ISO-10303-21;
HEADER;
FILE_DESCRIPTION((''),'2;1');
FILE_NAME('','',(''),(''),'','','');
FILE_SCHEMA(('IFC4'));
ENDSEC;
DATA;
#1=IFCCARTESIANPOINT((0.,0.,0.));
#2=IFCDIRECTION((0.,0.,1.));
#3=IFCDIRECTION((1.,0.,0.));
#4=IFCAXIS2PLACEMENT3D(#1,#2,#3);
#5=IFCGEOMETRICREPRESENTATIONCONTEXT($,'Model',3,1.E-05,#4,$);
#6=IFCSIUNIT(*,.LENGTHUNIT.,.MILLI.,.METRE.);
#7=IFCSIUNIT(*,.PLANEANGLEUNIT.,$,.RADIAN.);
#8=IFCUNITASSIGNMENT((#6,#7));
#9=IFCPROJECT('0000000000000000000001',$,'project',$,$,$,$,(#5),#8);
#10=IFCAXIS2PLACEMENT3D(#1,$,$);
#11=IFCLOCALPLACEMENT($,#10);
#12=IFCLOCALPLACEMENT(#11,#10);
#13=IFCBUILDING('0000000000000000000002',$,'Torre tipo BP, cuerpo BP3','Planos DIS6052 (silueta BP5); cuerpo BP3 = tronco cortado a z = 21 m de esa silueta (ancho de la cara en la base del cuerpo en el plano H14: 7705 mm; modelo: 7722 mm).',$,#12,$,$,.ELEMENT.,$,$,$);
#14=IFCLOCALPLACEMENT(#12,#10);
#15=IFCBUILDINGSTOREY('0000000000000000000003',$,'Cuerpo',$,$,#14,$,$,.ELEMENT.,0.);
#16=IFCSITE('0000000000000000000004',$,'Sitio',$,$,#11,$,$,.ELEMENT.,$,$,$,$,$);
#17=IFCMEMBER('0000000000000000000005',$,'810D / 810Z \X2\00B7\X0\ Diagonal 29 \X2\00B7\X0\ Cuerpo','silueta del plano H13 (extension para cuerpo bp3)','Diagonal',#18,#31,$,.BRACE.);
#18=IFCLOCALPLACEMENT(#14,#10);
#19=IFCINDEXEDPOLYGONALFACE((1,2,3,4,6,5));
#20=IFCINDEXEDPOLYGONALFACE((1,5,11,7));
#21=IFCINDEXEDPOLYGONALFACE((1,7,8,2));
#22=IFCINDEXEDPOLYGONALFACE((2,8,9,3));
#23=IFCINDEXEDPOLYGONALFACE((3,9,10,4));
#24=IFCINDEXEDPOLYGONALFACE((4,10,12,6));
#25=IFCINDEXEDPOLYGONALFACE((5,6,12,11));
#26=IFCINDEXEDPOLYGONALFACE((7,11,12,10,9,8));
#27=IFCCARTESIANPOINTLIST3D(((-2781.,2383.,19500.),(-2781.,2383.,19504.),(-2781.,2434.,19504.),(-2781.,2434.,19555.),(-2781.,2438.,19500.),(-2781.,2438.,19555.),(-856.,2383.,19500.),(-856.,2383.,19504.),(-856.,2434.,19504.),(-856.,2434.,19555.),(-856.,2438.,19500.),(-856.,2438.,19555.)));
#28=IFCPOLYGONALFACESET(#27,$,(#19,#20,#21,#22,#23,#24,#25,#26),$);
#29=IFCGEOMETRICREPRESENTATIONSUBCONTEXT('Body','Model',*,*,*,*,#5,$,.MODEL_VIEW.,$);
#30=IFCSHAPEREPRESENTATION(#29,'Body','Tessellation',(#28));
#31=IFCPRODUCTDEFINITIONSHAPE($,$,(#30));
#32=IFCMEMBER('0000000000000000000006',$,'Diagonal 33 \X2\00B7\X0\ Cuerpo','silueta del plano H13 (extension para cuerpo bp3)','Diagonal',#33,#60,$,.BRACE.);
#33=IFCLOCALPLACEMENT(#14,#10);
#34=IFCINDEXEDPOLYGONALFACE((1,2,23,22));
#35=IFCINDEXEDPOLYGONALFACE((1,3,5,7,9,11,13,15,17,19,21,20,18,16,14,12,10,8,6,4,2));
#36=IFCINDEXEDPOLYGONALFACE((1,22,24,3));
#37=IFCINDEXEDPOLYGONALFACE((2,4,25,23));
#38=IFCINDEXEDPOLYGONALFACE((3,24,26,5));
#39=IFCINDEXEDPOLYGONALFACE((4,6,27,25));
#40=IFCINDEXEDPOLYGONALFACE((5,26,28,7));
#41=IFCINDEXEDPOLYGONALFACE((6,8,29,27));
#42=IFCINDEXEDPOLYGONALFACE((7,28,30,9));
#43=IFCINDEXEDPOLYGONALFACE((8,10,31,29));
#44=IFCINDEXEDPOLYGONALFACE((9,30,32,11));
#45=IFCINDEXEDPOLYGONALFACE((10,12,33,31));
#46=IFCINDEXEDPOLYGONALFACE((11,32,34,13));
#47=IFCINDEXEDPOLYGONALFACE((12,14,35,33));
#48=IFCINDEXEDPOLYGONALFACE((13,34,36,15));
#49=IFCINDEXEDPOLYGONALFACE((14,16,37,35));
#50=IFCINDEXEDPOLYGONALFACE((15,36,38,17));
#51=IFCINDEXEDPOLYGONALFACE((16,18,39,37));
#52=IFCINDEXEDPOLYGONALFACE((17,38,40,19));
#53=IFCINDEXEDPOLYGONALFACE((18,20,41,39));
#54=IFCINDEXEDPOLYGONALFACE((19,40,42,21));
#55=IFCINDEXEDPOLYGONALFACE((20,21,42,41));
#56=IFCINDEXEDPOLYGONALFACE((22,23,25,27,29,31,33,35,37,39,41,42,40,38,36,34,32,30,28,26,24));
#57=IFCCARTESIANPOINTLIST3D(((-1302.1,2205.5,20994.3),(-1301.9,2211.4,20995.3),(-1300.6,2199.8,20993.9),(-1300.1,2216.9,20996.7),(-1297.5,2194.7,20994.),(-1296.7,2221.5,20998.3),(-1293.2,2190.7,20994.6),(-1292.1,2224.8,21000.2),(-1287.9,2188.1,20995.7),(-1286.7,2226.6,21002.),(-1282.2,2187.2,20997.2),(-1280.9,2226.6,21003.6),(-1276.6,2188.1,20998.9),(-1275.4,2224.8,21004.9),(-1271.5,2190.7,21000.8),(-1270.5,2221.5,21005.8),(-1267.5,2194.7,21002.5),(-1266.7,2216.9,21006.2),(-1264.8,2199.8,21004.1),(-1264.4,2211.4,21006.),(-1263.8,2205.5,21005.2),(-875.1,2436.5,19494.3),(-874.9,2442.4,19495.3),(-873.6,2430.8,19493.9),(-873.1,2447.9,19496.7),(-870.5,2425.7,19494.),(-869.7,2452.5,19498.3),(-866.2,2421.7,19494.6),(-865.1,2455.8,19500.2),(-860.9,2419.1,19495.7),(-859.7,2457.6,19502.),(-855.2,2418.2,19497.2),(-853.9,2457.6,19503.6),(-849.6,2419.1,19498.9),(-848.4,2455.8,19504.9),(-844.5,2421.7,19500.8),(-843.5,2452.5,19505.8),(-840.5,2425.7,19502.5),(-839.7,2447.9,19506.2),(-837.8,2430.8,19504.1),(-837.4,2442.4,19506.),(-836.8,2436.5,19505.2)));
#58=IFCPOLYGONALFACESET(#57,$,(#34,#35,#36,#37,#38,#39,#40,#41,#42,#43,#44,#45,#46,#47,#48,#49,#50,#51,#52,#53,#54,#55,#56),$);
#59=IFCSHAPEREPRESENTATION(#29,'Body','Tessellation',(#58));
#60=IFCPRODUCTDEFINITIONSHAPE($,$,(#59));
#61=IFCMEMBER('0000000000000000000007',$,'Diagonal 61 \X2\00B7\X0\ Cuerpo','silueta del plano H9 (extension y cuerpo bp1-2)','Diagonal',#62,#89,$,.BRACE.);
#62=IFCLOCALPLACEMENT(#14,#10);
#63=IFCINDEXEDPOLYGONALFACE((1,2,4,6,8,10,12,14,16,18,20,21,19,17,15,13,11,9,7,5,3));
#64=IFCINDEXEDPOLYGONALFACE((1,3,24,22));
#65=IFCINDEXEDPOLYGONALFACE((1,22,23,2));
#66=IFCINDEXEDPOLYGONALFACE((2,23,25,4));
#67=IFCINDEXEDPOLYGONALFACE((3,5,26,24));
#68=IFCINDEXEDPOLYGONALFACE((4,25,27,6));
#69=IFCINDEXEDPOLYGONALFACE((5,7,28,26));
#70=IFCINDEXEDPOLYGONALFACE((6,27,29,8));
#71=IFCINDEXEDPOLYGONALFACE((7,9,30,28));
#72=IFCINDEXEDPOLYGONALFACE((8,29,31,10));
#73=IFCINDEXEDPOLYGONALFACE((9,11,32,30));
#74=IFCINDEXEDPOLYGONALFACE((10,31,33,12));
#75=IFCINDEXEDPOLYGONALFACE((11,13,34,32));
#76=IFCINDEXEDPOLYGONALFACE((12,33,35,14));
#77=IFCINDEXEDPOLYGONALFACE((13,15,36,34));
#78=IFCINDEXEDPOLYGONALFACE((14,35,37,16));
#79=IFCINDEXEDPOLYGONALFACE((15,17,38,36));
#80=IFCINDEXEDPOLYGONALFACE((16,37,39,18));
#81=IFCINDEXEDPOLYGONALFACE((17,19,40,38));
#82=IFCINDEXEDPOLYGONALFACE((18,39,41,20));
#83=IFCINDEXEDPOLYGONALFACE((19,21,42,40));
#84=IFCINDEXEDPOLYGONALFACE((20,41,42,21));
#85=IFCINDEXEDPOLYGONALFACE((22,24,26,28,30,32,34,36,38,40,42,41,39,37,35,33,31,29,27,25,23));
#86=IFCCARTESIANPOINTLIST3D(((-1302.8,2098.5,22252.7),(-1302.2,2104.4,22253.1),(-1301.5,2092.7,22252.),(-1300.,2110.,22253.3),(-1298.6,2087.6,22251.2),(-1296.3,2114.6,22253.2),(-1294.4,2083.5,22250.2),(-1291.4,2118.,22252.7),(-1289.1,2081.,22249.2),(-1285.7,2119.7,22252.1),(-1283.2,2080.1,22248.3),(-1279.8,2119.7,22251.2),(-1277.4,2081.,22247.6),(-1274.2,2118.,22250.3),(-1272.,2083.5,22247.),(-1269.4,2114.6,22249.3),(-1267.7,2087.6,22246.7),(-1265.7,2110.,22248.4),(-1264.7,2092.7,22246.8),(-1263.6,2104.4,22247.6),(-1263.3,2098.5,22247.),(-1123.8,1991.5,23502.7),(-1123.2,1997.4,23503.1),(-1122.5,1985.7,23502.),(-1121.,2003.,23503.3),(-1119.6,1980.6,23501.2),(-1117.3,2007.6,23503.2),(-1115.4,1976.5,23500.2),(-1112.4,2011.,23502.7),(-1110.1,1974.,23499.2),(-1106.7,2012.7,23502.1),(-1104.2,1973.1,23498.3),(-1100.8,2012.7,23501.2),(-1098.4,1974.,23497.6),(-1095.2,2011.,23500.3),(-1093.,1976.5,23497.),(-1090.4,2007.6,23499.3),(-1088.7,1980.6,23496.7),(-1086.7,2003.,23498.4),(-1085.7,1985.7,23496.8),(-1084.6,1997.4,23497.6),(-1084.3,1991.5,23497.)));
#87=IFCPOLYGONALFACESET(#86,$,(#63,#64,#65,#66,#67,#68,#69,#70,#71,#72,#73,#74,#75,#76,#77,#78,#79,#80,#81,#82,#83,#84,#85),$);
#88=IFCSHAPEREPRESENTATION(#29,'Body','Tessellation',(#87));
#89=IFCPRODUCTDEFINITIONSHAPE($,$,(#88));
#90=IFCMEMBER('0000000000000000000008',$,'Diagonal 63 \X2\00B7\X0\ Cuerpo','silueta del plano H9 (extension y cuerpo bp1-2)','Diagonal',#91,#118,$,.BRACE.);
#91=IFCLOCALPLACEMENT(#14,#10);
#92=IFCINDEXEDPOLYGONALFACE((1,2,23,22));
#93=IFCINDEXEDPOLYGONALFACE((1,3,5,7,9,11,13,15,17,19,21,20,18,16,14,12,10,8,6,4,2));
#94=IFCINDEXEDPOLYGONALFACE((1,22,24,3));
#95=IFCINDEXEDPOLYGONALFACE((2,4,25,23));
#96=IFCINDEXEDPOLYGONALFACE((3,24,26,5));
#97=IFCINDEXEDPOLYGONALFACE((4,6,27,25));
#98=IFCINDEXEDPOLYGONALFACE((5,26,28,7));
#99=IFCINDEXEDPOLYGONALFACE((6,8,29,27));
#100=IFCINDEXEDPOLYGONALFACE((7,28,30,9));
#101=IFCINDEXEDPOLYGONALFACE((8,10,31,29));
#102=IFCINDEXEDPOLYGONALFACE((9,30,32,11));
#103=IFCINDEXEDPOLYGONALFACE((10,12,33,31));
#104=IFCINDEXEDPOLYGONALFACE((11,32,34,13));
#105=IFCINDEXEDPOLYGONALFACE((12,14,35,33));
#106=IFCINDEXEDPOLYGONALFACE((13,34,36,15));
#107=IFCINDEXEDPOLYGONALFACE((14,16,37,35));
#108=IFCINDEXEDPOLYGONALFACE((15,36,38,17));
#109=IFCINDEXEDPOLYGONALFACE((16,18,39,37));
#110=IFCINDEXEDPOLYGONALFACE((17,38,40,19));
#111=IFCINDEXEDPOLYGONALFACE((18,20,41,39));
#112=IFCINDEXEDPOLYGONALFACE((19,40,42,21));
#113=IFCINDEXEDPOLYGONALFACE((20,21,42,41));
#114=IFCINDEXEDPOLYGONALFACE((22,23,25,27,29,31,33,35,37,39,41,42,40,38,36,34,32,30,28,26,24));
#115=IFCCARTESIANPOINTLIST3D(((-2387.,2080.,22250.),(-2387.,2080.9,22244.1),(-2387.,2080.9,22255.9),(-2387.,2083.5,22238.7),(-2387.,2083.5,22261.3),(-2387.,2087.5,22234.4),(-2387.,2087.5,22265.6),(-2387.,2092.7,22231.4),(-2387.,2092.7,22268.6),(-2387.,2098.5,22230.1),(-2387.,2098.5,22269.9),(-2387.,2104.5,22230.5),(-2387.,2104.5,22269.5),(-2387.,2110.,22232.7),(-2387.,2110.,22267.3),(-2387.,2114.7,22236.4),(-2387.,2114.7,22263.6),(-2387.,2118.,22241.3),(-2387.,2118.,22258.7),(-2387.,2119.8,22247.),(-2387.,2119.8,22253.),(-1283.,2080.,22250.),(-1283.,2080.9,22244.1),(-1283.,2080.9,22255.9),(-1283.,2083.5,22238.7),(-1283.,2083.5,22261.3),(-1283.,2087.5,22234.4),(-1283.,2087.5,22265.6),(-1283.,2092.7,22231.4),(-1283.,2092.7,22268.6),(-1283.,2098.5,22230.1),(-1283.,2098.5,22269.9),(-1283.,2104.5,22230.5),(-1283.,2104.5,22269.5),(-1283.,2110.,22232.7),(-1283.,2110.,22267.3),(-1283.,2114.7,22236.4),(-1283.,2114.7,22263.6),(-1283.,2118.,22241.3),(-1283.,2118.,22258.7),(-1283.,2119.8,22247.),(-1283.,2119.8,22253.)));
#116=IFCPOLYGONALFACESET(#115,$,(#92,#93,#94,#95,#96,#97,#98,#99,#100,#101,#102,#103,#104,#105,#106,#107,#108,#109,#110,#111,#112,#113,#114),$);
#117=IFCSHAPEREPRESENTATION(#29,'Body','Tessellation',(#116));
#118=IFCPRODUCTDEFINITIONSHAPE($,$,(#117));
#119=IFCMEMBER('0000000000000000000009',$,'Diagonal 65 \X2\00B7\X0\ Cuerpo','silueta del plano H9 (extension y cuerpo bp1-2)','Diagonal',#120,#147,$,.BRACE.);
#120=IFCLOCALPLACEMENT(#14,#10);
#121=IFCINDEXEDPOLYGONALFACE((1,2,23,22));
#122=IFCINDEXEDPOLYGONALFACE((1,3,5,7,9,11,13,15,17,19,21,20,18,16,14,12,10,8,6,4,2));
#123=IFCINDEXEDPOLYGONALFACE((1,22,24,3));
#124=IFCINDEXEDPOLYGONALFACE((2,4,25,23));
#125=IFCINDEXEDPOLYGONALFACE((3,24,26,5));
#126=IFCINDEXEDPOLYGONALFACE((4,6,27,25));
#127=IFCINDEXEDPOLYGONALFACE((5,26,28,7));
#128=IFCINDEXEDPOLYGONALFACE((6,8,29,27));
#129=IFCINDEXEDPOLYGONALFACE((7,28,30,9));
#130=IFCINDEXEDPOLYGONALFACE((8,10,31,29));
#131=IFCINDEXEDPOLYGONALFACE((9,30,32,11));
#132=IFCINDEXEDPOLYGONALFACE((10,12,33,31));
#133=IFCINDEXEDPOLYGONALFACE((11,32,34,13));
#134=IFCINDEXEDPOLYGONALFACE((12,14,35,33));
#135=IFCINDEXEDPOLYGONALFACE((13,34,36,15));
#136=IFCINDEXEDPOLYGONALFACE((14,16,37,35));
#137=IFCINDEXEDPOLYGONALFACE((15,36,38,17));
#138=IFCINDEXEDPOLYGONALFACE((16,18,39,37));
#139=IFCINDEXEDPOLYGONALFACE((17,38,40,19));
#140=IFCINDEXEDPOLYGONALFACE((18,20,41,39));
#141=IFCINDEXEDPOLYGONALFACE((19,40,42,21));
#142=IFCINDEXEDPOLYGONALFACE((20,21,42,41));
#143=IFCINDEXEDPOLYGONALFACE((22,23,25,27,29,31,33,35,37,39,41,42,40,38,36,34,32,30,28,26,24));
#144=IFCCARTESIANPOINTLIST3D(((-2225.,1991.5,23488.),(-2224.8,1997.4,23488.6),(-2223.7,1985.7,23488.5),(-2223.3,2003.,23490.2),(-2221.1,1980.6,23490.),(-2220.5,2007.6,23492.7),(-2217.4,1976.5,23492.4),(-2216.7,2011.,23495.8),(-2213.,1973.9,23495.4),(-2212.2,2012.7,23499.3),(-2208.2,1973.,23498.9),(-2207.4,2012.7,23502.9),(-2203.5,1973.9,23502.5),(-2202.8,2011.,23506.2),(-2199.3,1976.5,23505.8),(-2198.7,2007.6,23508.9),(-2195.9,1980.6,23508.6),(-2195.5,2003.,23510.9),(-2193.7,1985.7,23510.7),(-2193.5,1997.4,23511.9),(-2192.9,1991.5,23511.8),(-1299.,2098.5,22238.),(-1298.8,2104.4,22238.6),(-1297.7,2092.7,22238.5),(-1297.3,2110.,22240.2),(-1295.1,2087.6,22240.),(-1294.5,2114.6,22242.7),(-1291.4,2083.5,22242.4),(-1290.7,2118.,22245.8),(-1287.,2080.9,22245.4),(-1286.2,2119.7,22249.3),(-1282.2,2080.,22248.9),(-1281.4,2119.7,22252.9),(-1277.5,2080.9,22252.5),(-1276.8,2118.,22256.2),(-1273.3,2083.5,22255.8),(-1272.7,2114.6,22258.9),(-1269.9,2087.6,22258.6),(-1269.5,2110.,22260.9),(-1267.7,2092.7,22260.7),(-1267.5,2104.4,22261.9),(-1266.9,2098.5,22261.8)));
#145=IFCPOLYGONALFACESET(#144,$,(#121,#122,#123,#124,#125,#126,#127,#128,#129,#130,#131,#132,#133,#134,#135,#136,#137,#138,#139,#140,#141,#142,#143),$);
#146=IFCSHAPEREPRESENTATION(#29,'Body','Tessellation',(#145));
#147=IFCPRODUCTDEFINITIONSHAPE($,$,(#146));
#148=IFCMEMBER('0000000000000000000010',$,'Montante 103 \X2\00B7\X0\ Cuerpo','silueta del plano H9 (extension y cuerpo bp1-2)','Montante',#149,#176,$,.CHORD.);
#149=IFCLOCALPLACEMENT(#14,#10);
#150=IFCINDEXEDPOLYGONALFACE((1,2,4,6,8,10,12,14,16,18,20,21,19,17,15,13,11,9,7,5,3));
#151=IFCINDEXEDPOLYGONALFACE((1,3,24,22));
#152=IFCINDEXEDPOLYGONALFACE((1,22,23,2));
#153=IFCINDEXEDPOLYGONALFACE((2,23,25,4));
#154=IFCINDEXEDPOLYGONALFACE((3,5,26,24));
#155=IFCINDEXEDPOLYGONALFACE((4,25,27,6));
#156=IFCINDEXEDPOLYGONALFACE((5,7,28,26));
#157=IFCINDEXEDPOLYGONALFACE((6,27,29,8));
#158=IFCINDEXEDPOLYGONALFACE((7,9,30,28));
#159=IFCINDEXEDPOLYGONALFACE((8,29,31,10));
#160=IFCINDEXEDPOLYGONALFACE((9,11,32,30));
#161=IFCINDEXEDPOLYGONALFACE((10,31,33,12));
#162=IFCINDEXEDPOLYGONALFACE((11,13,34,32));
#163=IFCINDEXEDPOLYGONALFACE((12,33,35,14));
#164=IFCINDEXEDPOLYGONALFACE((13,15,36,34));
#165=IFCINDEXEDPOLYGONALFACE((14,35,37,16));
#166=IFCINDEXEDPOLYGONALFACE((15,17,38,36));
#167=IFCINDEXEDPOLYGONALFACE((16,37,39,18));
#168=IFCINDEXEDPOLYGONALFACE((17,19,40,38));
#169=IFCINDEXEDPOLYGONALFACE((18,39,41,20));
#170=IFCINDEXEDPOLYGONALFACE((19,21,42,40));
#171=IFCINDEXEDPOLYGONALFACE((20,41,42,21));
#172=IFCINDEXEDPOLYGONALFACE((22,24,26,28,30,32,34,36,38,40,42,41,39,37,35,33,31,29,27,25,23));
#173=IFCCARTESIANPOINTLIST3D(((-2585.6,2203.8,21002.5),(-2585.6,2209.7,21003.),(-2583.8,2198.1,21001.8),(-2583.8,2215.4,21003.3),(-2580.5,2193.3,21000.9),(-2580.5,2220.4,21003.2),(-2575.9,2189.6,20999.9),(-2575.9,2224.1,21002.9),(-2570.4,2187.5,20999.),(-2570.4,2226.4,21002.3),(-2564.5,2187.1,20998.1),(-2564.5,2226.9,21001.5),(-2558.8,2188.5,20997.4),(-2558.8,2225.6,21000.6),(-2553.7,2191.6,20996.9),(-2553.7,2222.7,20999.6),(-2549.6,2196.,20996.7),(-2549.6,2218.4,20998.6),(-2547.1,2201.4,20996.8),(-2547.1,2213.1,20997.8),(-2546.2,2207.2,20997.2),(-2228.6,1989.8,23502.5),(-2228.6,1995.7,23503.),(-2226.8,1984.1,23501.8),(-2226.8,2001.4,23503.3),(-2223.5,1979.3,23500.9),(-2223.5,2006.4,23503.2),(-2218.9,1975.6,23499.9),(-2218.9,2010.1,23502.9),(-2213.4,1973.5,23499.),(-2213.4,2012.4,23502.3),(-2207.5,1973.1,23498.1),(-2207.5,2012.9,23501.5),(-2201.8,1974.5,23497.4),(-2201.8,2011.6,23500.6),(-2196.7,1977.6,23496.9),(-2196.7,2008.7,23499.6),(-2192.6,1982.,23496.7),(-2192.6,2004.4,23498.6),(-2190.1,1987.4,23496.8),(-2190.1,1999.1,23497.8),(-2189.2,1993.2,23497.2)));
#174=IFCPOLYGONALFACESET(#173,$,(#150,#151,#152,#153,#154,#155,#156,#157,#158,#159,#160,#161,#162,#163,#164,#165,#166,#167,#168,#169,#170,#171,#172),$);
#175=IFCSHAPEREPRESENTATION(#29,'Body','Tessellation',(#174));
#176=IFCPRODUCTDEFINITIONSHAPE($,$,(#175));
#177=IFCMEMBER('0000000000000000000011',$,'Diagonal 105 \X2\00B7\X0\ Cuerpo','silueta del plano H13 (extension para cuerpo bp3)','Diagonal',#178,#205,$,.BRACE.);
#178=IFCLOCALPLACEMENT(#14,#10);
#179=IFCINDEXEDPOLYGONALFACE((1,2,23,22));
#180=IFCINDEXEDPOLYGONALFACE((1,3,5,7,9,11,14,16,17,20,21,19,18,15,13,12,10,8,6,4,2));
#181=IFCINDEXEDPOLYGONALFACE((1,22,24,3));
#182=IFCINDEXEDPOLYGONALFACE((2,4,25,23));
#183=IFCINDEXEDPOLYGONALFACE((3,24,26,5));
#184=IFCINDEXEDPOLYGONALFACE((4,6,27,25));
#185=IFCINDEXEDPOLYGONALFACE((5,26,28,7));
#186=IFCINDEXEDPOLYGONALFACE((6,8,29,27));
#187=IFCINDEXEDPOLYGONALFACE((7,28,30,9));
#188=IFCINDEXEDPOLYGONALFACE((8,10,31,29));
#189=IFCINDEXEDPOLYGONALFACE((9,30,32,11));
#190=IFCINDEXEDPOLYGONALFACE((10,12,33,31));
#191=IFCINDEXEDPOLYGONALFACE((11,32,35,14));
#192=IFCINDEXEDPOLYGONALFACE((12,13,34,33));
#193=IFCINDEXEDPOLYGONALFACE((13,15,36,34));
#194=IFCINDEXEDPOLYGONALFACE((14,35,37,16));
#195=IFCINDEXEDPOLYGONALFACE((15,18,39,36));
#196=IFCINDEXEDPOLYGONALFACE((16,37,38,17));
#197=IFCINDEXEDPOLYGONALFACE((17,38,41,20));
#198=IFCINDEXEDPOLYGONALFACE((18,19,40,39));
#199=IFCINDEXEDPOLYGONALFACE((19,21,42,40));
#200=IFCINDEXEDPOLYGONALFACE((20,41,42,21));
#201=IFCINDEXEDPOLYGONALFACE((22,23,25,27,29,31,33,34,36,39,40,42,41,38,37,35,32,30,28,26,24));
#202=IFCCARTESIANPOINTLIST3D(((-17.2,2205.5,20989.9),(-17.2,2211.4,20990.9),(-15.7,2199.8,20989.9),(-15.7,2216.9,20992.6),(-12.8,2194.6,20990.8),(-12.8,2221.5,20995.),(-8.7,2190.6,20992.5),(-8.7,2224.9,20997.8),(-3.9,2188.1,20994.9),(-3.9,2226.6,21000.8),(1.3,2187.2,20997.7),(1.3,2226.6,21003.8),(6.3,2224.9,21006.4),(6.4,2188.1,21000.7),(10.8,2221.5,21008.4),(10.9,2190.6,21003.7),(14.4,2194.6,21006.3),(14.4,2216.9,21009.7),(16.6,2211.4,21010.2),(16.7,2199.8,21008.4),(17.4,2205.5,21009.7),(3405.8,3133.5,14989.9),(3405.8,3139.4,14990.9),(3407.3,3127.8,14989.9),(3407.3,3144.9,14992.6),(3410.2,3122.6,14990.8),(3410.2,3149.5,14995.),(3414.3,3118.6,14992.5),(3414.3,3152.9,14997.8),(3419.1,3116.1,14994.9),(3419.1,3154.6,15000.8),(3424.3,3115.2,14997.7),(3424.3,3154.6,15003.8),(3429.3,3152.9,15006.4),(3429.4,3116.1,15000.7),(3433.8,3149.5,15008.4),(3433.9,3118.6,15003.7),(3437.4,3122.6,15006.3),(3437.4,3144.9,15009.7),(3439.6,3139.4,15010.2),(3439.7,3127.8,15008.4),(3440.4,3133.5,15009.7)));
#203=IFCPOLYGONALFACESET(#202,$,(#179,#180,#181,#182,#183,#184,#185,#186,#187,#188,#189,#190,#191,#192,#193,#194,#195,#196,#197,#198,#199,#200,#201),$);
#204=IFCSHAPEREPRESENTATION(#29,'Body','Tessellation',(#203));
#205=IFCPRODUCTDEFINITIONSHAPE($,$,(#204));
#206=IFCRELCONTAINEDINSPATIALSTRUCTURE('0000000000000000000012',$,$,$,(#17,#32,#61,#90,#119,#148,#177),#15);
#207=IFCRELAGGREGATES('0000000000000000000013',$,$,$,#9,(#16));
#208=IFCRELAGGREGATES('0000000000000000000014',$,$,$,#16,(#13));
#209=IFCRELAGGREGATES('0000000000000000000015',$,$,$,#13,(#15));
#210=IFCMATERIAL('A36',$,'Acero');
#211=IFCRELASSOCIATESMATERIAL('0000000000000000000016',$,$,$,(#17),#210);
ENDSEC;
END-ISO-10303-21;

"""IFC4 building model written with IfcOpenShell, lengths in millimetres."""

from ifc_helpers import new_model, si_unit, frame, frame_2d, origin, origin_with_axes, place, context, subcontext, project, spatial, circle, l_section, extrude, material, element, save


model = new_model("IFC4")

# Units and contexts
model_context = context("Model", 3, precision=1e-05, world=origin_with_axes())
body_context = subcontext(model_context, "Body", "Model", "MODEL_VIEW")
ifc_project = project(units=[si_unit("LENGTHUNIT", "METRE", prefix="MILLI"), si_unit("PLANEANGLEUNIT", "RADIAN")], contexts=[model_context])

# Site, building, storey
site_placement = place(None, origin())
site = spatial("IfcSite", under=ifc_project, at=site_placement, Name="Sitio", CompositionType="ELEMENT")
building_placement = place(site_placement, origin())
building = spatial("IfcBuilding", under=site, at=building_placement, Name="Torre tipo BP, cuerpo BP3", Description="Planos DIS6052 (silueta BP5); cuerpo BP3 = tronco cortado a z = 21 m de esa silueta (ancho de la cara en la base del cuerpo en el plano H14: 7705 mm; modelo: 7722 mm).", CompositionType="ELEMENT")
storey_placement = place(building_placement, origin())
storey = spatial("IfcBuildingStorey", under=building, at=storey_placement, Name="Cuerpo", CompositionType="ELEMENT", Elevation=0.0)

# Members
ifc_material_1 = material(Name="A36", Category="Acero")
member_1_placement = place(storey_placement, frame((-856.0, 2438.0, 19500.0), z_axis=(-1.0, 0.0, 0.0), x_axis=(0.0, -1.0, 0.0)))
element("IfcMember", 1, at=member_1_placement, inside=storey, material=ifc_material_1, Name="810D / 810Z · Diagonal 29 · Cuerpo", Description="silueta del plano H13 (extension para cuerpo bp3)", ObjectType="Diagonal", PredefinedType="BRACE", context=body_context, shape_type="SweptSolid", body=[
    extrude(l_section(Depth=55.0, Width=55.0, Thickness=4.0, at=frame_2d((27.5, 27.5))), None, (0.0, 0.0, 1.0), 1925.0),
])
member_2_placement = place(storey_placement, frame((-856.0, 2438.0, 19500.0), z_axis=(-0.270835, -0.146517, 0.95141), x_axis=(0.040115, -0.989208, -0.140919)))
element("IfcMember", 2, at=member_2_placement, inside=storey, Name="Diagonal 33 · Cuerpo", Description="silueta del plano H13 (extension para cuerpo bp3)", ObjectType="Diagonal", PredefinedType="BRACE", context=body_context, shape_type="SweptSolid", body=[
    extrude(circle(Radius=20.0), None, (0.0, 0.0, 1.0), 1576.6),
])
member_3_placement = place(storey_placement, frame((-1104.0, 1993.0, 23500.0), z_axis=(-0.141248, 0.084433, -0.986367), x_axis=(-0.011969, -0.996429, -0.08358)))
element("IfcMember", 3, at=member_3_placement, inside=storey, Name="Diagonal 61 · Cuerpo", Description="silueta del plano H9 (extension y cuerpo bp1-2)", ObjectType="Diagonal", PredefinedType="BRACE", context=body_context, shape_type="SweptSolid", body=[
    extrude(circle(Radius=20.0), None, (0.0, 0.0, 1.0), 1267.3),
])
member_4_placement = place(storey_placement, frame((-1283.0, 2100.0, 22250.0), z_axis=(-1.0, 0.0, 0.0), x_axis=(0.0, -1.0, 0.0)))
element("IfcMember", 4, at=member_4_placement, inside=storey, Name="Diagonal 63 · Cuerpo", Description="silueta del plano H9 (extension y cuerpo bp1-2)", ObjectType="Diagonal", PredefinedType="BRACE", context=body_context, shape_type="SweptSolid", body=[
    extrude(circle(Radius=20.0), None, (0.0, 0.0, 1.0), 1104.0),
])
member_5_placement = place(storey_placement, frame((-1283.0, 2100.0, 22250.0), z_axis=(-0.593855, -0.06862, 0.80164), x_axis=(0.040847, -0.997643, -0.055139)))
element("IfcMember", 5, at=member_5_placement, inside=storey, Name="Diagonal 65 · Cuerpo", Description="silueta del plano H9 (extension y cuerpo bp1-2)", ObjectType="Diagonal", PredefinedType="BRACE", context=body_context, shape_type="SweptSolid", body=[
    extrude(circle(Radius=20.0), None, (0.0, 0.0, 1.0), 1559.3),
])
member_6_placement = place(storey_placement, frame((-2209.0, 1993.0, 23500.0), z_axis=(-0.140861, 0.084438, -0.986422), x_axis=(0.990029, 0.012014, -0.140348)))
element("IfcMember", 6, at=member_6_placement, inside=storey, Name="Montante 103 · Cuerpo", Description="silueta del plano H9 (extension y cuerpo bp1-2)", ObjectType="Montante", PredefinedType="CHORD", context=body_context, shape_type="SweptSolid", body=[
    extrude(circle(Radius=20.0), None, (0.0, 0.0, 1.0), 2534.4),
])
member_7_placement = place(storey_placement, frame((0.0, 2207.0, 21000.0), z_axis=(0.491119, 0.133146, -0.860857), x_axis=(0.065978, -0.991096, -0.115649)))
element("IfcMember", 7, at=member_7_placement, inside=storey, Name="Diagonal 105 · Cuerpo", Description="silueta del plano H13 (extension para cuerpo bp3)", ObjectType="Diagonal", PredefinedType="BRACE", context=body_context, shape_type="SweptSolid", body=[
    extrude(circle(Radius=20.0), None, (0.0, 0.0, 1.0), 6969.8),
])

save(model, "model.ifc")
